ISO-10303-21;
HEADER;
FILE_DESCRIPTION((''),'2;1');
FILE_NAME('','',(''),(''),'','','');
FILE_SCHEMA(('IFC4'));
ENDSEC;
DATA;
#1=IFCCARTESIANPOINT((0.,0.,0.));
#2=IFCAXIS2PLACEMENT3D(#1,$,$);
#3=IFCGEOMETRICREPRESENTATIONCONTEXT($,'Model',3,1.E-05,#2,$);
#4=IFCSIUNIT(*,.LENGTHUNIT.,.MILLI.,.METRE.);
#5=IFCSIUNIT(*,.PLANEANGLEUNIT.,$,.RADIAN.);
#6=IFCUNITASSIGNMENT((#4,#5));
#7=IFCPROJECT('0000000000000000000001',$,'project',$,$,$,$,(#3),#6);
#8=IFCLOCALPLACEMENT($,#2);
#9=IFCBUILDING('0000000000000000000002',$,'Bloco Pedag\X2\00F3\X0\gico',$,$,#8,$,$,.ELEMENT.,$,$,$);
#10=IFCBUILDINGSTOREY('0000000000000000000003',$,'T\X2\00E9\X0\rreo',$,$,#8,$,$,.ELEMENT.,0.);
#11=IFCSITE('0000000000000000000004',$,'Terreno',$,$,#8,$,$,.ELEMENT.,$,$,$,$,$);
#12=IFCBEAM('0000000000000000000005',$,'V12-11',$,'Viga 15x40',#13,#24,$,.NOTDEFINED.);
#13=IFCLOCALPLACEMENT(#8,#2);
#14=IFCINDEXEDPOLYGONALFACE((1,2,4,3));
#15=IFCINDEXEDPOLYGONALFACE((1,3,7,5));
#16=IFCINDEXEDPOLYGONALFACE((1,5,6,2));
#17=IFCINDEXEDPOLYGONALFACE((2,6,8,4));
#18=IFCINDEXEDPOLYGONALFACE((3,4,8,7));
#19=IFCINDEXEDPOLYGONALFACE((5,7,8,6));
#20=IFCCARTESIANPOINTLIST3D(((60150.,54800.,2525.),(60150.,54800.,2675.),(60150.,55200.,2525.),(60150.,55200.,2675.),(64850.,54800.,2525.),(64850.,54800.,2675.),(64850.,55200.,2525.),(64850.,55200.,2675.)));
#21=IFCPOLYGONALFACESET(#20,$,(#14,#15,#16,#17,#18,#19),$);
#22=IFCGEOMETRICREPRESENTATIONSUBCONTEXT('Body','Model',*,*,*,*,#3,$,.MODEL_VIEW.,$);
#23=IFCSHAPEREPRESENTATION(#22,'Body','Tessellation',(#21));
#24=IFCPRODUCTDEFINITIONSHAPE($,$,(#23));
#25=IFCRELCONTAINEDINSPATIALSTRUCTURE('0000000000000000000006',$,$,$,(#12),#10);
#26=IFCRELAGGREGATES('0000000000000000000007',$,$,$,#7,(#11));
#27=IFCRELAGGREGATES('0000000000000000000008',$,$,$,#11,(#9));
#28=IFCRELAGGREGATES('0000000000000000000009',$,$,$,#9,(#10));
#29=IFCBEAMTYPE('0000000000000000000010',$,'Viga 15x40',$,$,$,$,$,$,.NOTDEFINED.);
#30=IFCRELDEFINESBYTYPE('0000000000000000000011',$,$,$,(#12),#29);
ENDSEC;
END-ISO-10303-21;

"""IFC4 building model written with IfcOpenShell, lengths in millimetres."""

from ifc_helpers import new_model, si_unit, frame, origin, origin_2d, place, context, subcontext, project, spatial, rectangle, extrude, type_object, element, save


model = new_model("IFC4")

# Units and contexts
model_context = context("Model", 3, precision=1e-05, world=origin())
body_context = subcontext(model_context, "Body", "Model", "MODEL_VIEW")
ifc_project = project(units=[si_unit("LENGTHUNIT", "METRE", prefix="MILLI"), si_unit("PLANEANGLEUNIT", "RADIAN")], contexts=[model_context])

# Site, building, storey
placement = place(None, origin())
site = spatial("IfcSite", under=ifc_project, at=placement, Name="Terreno", CompositionType="ELEMENT")
building = spatial("IfcBuilding", under=site, at=placement, Name="Bloco Pedagógico", CompositionType="ELEMENT")
storey = spatial("IfcBuildingStorey", under=building, at=placement, Name="Térreo", CompositionType="ELEMENT", Elevation=0.0)

# Beam
beam_type = type_object("IfcBeamType", Name="Viga 15x40", PredefinedType="NOTDEFINED")
for number, where, z_axis, x_axis, name in (
    (1, (60150.0, 55000.0, 2600.0), (1.0, 0.0, 0.0), (0.0, 1.0, 0.0), "V12-11"),
):
    element("IfcBeam", number, at=place(None, frame(where, z_axis=z_axis, x_axis=x_axis)), inside=storey, type_object=beam_type, Name=name, ObjectType="Viga 15x40", PredefinedType="NOTDEFINED", context=body_context, shape_type="SweptSolid", body=[
        extrude(rectangle(XDim=400.0, YDim=150.0, at=origin_2d()), None, (0.0, 0.0, 1.0), 4700.0),
    ])

save(model, "model.ifc")
